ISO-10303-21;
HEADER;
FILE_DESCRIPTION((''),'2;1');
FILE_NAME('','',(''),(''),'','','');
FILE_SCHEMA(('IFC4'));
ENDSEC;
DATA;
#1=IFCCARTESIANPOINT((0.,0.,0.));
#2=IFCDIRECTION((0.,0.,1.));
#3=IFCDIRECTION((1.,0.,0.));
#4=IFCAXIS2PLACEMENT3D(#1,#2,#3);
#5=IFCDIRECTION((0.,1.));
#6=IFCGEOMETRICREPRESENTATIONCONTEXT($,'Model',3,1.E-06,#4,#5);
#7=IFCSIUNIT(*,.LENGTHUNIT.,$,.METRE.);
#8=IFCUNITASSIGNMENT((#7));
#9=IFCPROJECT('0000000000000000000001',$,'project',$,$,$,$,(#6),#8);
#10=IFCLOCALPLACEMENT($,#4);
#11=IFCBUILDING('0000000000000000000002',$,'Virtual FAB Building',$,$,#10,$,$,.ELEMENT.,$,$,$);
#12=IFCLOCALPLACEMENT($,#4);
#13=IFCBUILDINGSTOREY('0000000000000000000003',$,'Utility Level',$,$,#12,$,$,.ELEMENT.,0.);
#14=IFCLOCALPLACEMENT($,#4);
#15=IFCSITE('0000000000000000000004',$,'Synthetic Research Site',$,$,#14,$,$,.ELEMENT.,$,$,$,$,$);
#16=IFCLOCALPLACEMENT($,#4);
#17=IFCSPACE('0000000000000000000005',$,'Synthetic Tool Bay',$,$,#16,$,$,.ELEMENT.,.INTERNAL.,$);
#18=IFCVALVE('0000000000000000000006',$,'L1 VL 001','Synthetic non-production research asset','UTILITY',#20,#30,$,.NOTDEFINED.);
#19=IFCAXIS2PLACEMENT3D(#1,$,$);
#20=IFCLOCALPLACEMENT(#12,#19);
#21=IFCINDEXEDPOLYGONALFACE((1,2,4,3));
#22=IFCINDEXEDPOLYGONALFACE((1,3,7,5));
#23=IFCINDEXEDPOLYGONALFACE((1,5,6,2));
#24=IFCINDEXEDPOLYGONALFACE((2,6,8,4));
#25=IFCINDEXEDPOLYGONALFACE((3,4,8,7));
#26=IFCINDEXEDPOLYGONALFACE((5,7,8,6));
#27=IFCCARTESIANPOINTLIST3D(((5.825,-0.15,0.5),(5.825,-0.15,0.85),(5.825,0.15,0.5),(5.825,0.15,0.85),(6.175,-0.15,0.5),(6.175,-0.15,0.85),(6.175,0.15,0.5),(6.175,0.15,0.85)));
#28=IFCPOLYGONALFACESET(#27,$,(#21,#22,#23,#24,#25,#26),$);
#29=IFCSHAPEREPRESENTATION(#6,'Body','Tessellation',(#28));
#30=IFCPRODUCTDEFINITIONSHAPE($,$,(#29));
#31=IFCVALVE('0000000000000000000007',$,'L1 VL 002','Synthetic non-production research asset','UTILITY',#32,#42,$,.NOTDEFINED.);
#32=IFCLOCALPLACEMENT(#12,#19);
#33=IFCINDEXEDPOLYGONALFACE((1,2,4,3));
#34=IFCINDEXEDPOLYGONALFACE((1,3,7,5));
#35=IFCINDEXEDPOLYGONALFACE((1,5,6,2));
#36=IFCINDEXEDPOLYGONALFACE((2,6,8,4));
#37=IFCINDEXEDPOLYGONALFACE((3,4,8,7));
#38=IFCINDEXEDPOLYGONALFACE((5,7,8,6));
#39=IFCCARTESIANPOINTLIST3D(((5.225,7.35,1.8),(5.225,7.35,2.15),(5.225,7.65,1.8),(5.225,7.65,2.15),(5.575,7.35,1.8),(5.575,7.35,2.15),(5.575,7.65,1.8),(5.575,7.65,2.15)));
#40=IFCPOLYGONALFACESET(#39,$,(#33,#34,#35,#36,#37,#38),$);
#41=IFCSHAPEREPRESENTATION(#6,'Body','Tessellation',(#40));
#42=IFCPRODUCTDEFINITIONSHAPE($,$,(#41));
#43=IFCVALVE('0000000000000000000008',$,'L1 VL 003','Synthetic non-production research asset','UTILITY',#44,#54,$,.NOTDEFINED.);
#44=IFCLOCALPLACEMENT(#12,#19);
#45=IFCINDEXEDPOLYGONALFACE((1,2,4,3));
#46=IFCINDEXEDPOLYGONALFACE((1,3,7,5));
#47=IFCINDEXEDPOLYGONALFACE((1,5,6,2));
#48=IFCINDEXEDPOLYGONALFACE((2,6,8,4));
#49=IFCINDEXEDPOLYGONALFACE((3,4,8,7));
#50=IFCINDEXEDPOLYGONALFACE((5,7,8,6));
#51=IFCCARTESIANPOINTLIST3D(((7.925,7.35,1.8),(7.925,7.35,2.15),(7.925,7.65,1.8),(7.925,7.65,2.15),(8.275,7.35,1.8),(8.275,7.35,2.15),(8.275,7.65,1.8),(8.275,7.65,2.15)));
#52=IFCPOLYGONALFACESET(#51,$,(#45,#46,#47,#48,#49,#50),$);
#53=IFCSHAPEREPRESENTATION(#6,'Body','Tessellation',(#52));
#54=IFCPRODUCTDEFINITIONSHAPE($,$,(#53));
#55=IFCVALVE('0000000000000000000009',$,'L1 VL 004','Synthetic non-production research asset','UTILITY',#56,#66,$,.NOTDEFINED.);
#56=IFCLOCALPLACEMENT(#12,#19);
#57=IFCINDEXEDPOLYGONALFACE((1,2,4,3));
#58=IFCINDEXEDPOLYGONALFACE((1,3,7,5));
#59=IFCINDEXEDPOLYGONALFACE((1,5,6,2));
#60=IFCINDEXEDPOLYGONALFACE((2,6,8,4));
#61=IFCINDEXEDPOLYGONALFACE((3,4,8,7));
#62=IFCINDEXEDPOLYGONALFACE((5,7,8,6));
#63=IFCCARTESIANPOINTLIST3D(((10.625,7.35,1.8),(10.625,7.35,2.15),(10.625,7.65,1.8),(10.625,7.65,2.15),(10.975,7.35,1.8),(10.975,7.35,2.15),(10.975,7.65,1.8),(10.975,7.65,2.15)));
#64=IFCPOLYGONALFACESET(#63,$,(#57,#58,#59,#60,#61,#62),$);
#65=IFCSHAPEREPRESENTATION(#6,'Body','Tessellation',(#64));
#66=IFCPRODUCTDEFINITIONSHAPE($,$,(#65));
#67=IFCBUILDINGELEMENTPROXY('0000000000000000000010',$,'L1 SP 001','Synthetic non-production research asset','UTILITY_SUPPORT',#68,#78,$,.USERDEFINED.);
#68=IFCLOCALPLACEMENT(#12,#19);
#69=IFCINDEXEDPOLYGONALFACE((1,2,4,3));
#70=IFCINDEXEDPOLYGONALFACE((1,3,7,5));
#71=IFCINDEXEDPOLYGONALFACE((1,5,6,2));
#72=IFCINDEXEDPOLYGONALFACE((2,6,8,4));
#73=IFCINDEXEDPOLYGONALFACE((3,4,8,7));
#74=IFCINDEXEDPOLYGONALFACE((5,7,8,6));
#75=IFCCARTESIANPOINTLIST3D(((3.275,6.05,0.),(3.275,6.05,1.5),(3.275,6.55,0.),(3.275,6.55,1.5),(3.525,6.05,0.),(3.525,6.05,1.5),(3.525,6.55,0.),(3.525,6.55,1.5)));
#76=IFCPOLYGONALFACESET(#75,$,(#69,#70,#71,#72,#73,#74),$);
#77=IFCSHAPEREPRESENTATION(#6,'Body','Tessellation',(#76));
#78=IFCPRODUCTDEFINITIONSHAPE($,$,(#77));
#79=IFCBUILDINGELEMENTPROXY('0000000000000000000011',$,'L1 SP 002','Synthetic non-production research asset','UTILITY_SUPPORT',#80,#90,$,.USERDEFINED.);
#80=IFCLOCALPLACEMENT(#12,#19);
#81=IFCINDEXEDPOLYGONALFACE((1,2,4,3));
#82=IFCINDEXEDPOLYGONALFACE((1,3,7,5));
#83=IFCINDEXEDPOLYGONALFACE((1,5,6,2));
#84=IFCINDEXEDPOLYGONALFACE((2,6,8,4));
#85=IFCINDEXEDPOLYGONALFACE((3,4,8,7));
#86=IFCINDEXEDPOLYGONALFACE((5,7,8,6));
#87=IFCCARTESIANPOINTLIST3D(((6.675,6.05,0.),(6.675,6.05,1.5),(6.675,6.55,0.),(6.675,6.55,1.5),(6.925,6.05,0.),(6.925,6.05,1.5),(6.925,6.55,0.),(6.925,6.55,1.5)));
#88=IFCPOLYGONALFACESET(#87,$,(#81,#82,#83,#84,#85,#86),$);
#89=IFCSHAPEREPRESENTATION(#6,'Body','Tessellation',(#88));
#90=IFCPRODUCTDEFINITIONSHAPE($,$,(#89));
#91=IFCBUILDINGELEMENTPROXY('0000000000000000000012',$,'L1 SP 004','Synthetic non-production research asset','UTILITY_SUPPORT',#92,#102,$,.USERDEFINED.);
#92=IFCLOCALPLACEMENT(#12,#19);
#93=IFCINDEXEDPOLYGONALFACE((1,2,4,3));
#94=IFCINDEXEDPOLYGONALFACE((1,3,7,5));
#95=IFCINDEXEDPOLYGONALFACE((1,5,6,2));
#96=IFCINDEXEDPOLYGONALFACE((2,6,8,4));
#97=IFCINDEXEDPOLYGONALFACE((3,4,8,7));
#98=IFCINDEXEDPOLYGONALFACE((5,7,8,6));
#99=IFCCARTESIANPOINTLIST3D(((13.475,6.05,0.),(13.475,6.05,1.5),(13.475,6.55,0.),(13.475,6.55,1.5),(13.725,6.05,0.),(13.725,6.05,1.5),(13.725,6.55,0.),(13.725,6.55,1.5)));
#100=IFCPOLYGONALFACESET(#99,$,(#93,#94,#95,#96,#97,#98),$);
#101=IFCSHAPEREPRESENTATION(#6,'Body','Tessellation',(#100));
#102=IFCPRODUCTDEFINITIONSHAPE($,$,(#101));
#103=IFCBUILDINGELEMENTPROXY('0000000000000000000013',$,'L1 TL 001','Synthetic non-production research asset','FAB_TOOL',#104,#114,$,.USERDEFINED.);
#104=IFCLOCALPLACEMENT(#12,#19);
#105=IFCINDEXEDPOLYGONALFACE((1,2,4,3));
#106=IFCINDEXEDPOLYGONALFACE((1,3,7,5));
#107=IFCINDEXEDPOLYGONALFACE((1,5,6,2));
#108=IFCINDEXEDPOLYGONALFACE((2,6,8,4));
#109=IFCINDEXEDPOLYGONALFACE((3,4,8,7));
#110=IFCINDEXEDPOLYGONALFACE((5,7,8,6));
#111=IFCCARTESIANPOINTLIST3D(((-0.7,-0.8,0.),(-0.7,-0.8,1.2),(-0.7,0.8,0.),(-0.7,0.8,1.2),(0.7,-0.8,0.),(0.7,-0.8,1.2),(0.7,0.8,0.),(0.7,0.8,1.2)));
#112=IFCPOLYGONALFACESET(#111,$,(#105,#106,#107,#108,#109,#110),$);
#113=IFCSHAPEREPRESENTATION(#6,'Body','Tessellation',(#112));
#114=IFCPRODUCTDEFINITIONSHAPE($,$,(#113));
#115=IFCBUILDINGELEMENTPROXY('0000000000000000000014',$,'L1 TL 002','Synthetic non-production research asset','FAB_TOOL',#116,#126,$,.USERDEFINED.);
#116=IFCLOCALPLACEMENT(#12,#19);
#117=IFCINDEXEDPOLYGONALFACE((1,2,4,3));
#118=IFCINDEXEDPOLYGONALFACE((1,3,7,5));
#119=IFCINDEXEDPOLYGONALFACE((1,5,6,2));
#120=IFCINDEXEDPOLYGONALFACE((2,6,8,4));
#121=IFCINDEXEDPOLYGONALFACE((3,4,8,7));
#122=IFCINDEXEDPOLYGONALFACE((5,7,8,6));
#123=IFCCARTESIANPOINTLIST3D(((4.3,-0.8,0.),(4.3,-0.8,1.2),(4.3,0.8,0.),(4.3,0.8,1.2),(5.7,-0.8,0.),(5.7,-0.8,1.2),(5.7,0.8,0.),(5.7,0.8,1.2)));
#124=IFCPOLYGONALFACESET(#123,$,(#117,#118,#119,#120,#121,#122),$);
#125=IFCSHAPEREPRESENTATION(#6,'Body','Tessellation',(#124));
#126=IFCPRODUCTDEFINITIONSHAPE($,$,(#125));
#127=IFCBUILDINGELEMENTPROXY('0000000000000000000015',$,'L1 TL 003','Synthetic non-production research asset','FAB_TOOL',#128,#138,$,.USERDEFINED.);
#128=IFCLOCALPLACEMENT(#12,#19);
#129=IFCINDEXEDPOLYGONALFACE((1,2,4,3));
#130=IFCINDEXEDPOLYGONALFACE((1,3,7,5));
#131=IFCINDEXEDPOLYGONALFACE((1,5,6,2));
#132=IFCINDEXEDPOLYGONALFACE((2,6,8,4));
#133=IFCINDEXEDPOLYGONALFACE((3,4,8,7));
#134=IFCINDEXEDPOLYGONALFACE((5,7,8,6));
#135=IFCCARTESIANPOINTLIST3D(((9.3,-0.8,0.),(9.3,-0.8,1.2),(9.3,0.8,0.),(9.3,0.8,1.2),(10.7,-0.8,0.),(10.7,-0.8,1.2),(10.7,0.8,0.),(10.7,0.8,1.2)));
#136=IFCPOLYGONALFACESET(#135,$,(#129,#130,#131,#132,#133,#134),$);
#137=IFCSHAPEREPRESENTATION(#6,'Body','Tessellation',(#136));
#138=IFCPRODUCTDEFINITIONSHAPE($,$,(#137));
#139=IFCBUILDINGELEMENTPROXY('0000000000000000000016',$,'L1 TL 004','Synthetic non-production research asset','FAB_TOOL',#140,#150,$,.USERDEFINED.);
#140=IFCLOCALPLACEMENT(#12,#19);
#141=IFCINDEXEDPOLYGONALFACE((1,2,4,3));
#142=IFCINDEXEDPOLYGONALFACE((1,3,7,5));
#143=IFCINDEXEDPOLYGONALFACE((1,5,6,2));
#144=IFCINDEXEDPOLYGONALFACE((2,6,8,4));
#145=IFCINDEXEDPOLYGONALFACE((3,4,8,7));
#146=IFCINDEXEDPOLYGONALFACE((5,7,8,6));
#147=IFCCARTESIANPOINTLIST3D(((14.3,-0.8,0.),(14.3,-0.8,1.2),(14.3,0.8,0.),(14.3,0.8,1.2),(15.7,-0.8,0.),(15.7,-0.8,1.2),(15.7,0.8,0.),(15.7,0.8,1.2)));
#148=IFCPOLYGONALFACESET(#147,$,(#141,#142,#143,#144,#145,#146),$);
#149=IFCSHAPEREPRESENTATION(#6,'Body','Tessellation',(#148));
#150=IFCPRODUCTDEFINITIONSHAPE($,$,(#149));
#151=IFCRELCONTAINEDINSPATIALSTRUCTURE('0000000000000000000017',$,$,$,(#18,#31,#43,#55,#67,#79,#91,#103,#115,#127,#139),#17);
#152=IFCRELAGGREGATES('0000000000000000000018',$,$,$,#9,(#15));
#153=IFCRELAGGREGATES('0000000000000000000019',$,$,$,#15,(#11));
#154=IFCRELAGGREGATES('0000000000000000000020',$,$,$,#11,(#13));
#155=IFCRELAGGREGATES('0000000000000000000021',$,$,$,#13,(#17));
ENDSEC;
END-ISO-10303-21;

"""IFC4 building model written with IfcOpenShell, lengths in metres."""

from ifc_helpers import new_model, si_unit, direction, frame, origin_with_axes, origin_2d_with_axis, place, context, project, spatial, rectangle, extrude, element, save


model = new_model("IFC4")

# Units and contexts
model_context = context("Model", 3, precision=1e-06, world=origin_with_axes(), true_north=direction((0.0, 1.0)))
ifc_project = project(units=[si_unit("LENGTHUNIT", "METRE")], contexts=[model_context])

# Site, building, storey, space
site_placement = place(None, origin_with_axes())
site = spatial("IfcSite", under=ifc_project, at=site_placement, Name="Synthetic Research Site", CompositionType="ELEMENT")
building_placement = place(None, origin_with_axes())
building = spatial("IfcBuilding", under=site, at=building_placement, Name="Virtual FAB Building", CompositionType="ELEMENT")
storey_placement = place(None, origin_with_axes())
storey = spatial("IfcBuildingStorey", under=building, at=storey_placement, Name="Utility Level", CompositionType="ELEMENT", Elevation=0.0)
space_placement = place(None, origin_with_axes())
space = spatial("IfcSpace", under=storey, at=space_placement, Name="Synthetic Tool Bay", CompositionType="ELEMENT", PredefinedType="INTERNAL")

# Valves
for number, where, z_axis, x_axis, name in (
    (1, (6.0, 0.0, 0.5), (0.0, 0.0, 1.0), (1.0, 0.0, 0.0), "L1 VL 001"),
    (2, (5.4, 7.5, 1.8), (0.0, 0.0, 1.0), (1.0, 0.0, 0.0), "L1 VL 002"),
    (3, (8.1, 7.5, 1.8), (0.0, 0.0, 1.0), (1.0, 0.0, 0.0), "L1 VL 003"),
    (4, (10.8, 7.5, 1.8), (0.0, 0.0, 1.0), (1.0, 0.0, 0.0), "L1 VL 004"),
):
    element("IfcValve", number, at=place(None, frame(where, z_axis=z_axis, x_axis=x_axis)), inside=space, Name=name, Description="Synthetic non-production research asset", ObjectType="UTILITY", PredefinedType="NOTDEFINED", context=model_context, shape_type="SweptSolid", body=[
        extrude(rectangle(XDim=0.35, YDim=0.3, at=origin_2d_with_axis()), origin_with_axes(), (0.0, 0.0, 1.0), 0.35),
    ])

# Building element proxies
for number, where, z_axis, x_axis, name in (
    (5, (3.4, 6.3, 0.0), (0.0, 0.0, 1.0), (1.0, 0.0, 0.0), "L1 SP 001"),
    (6, (6.8, 6.3, 0.0), (0.0, 0.0, 1.0), (1.0, 0.0, 0.0), "L1 SP 002"),
    (7, (13.6, 6.3, 0.0), (0.0, 0.0, 1.0), (1.0, 0.0, 0.0), "L1 SP 004"),
):
    element("IfcBuildingElementProxy", number, at=place(None, frame(where, z_axis=z_axis, x_axis=x_axis)), inside=space, Name=name, Description="Synthetic non-production research asset", ObjectType="UTILITY_SUPPORT", PredefinedType="USERDEFINED", context=model_context, shape_type="SweptSolid", body=[
        extrude(rectangle(XDim=0.25, YDim=0.5, at=origin_2d_with_axis()), origin_with_axes(), (0.0, 0.0, 1.0), 1.5),
    ])
for number, where, z_axis, x_axis, name in (
    (8, (0.0, 0.0, 0.0), (0.0, 0.0, 1.0), (1.0, 0.0, 0.0), "L1 TL 001"),
    (9, (5.0, 0.0, 0.0), (0.0, 0.0, 1.0), (1.0, 0.0, 0.0), "L1 TL 002"),
    (10, (10.0, 0.0, 0.0), (0.0, 0.0, 1.0), (1.0, 0.0, 0.0), "L1 TL 003"),
    (11, (15.0, 0.0, 0.0), (0.0, 0.0, 1.0), (1.0, 0.0, 0.0), "L1 TL 004"),
):
    element("IfcBuildingElementProxy", number, at=place(None, frame(where, z_axis=z_axis, x_axis=x_axis)), inside=space, Name=name, Description="Synthetic non-production research asset", ObjectType="FAB_TOOL", PredefinedType="USERDEFINED", context=model_context, shape_type="SweptSolid", body=[
        extrude(rectangle(XDim=1.4, YDim=1.6, at=origin_2d_with_axis()), origin_with_axes(), (0.0, 0.0, 1.0), 1.2),
    ])

save(model, "model.ifc")
